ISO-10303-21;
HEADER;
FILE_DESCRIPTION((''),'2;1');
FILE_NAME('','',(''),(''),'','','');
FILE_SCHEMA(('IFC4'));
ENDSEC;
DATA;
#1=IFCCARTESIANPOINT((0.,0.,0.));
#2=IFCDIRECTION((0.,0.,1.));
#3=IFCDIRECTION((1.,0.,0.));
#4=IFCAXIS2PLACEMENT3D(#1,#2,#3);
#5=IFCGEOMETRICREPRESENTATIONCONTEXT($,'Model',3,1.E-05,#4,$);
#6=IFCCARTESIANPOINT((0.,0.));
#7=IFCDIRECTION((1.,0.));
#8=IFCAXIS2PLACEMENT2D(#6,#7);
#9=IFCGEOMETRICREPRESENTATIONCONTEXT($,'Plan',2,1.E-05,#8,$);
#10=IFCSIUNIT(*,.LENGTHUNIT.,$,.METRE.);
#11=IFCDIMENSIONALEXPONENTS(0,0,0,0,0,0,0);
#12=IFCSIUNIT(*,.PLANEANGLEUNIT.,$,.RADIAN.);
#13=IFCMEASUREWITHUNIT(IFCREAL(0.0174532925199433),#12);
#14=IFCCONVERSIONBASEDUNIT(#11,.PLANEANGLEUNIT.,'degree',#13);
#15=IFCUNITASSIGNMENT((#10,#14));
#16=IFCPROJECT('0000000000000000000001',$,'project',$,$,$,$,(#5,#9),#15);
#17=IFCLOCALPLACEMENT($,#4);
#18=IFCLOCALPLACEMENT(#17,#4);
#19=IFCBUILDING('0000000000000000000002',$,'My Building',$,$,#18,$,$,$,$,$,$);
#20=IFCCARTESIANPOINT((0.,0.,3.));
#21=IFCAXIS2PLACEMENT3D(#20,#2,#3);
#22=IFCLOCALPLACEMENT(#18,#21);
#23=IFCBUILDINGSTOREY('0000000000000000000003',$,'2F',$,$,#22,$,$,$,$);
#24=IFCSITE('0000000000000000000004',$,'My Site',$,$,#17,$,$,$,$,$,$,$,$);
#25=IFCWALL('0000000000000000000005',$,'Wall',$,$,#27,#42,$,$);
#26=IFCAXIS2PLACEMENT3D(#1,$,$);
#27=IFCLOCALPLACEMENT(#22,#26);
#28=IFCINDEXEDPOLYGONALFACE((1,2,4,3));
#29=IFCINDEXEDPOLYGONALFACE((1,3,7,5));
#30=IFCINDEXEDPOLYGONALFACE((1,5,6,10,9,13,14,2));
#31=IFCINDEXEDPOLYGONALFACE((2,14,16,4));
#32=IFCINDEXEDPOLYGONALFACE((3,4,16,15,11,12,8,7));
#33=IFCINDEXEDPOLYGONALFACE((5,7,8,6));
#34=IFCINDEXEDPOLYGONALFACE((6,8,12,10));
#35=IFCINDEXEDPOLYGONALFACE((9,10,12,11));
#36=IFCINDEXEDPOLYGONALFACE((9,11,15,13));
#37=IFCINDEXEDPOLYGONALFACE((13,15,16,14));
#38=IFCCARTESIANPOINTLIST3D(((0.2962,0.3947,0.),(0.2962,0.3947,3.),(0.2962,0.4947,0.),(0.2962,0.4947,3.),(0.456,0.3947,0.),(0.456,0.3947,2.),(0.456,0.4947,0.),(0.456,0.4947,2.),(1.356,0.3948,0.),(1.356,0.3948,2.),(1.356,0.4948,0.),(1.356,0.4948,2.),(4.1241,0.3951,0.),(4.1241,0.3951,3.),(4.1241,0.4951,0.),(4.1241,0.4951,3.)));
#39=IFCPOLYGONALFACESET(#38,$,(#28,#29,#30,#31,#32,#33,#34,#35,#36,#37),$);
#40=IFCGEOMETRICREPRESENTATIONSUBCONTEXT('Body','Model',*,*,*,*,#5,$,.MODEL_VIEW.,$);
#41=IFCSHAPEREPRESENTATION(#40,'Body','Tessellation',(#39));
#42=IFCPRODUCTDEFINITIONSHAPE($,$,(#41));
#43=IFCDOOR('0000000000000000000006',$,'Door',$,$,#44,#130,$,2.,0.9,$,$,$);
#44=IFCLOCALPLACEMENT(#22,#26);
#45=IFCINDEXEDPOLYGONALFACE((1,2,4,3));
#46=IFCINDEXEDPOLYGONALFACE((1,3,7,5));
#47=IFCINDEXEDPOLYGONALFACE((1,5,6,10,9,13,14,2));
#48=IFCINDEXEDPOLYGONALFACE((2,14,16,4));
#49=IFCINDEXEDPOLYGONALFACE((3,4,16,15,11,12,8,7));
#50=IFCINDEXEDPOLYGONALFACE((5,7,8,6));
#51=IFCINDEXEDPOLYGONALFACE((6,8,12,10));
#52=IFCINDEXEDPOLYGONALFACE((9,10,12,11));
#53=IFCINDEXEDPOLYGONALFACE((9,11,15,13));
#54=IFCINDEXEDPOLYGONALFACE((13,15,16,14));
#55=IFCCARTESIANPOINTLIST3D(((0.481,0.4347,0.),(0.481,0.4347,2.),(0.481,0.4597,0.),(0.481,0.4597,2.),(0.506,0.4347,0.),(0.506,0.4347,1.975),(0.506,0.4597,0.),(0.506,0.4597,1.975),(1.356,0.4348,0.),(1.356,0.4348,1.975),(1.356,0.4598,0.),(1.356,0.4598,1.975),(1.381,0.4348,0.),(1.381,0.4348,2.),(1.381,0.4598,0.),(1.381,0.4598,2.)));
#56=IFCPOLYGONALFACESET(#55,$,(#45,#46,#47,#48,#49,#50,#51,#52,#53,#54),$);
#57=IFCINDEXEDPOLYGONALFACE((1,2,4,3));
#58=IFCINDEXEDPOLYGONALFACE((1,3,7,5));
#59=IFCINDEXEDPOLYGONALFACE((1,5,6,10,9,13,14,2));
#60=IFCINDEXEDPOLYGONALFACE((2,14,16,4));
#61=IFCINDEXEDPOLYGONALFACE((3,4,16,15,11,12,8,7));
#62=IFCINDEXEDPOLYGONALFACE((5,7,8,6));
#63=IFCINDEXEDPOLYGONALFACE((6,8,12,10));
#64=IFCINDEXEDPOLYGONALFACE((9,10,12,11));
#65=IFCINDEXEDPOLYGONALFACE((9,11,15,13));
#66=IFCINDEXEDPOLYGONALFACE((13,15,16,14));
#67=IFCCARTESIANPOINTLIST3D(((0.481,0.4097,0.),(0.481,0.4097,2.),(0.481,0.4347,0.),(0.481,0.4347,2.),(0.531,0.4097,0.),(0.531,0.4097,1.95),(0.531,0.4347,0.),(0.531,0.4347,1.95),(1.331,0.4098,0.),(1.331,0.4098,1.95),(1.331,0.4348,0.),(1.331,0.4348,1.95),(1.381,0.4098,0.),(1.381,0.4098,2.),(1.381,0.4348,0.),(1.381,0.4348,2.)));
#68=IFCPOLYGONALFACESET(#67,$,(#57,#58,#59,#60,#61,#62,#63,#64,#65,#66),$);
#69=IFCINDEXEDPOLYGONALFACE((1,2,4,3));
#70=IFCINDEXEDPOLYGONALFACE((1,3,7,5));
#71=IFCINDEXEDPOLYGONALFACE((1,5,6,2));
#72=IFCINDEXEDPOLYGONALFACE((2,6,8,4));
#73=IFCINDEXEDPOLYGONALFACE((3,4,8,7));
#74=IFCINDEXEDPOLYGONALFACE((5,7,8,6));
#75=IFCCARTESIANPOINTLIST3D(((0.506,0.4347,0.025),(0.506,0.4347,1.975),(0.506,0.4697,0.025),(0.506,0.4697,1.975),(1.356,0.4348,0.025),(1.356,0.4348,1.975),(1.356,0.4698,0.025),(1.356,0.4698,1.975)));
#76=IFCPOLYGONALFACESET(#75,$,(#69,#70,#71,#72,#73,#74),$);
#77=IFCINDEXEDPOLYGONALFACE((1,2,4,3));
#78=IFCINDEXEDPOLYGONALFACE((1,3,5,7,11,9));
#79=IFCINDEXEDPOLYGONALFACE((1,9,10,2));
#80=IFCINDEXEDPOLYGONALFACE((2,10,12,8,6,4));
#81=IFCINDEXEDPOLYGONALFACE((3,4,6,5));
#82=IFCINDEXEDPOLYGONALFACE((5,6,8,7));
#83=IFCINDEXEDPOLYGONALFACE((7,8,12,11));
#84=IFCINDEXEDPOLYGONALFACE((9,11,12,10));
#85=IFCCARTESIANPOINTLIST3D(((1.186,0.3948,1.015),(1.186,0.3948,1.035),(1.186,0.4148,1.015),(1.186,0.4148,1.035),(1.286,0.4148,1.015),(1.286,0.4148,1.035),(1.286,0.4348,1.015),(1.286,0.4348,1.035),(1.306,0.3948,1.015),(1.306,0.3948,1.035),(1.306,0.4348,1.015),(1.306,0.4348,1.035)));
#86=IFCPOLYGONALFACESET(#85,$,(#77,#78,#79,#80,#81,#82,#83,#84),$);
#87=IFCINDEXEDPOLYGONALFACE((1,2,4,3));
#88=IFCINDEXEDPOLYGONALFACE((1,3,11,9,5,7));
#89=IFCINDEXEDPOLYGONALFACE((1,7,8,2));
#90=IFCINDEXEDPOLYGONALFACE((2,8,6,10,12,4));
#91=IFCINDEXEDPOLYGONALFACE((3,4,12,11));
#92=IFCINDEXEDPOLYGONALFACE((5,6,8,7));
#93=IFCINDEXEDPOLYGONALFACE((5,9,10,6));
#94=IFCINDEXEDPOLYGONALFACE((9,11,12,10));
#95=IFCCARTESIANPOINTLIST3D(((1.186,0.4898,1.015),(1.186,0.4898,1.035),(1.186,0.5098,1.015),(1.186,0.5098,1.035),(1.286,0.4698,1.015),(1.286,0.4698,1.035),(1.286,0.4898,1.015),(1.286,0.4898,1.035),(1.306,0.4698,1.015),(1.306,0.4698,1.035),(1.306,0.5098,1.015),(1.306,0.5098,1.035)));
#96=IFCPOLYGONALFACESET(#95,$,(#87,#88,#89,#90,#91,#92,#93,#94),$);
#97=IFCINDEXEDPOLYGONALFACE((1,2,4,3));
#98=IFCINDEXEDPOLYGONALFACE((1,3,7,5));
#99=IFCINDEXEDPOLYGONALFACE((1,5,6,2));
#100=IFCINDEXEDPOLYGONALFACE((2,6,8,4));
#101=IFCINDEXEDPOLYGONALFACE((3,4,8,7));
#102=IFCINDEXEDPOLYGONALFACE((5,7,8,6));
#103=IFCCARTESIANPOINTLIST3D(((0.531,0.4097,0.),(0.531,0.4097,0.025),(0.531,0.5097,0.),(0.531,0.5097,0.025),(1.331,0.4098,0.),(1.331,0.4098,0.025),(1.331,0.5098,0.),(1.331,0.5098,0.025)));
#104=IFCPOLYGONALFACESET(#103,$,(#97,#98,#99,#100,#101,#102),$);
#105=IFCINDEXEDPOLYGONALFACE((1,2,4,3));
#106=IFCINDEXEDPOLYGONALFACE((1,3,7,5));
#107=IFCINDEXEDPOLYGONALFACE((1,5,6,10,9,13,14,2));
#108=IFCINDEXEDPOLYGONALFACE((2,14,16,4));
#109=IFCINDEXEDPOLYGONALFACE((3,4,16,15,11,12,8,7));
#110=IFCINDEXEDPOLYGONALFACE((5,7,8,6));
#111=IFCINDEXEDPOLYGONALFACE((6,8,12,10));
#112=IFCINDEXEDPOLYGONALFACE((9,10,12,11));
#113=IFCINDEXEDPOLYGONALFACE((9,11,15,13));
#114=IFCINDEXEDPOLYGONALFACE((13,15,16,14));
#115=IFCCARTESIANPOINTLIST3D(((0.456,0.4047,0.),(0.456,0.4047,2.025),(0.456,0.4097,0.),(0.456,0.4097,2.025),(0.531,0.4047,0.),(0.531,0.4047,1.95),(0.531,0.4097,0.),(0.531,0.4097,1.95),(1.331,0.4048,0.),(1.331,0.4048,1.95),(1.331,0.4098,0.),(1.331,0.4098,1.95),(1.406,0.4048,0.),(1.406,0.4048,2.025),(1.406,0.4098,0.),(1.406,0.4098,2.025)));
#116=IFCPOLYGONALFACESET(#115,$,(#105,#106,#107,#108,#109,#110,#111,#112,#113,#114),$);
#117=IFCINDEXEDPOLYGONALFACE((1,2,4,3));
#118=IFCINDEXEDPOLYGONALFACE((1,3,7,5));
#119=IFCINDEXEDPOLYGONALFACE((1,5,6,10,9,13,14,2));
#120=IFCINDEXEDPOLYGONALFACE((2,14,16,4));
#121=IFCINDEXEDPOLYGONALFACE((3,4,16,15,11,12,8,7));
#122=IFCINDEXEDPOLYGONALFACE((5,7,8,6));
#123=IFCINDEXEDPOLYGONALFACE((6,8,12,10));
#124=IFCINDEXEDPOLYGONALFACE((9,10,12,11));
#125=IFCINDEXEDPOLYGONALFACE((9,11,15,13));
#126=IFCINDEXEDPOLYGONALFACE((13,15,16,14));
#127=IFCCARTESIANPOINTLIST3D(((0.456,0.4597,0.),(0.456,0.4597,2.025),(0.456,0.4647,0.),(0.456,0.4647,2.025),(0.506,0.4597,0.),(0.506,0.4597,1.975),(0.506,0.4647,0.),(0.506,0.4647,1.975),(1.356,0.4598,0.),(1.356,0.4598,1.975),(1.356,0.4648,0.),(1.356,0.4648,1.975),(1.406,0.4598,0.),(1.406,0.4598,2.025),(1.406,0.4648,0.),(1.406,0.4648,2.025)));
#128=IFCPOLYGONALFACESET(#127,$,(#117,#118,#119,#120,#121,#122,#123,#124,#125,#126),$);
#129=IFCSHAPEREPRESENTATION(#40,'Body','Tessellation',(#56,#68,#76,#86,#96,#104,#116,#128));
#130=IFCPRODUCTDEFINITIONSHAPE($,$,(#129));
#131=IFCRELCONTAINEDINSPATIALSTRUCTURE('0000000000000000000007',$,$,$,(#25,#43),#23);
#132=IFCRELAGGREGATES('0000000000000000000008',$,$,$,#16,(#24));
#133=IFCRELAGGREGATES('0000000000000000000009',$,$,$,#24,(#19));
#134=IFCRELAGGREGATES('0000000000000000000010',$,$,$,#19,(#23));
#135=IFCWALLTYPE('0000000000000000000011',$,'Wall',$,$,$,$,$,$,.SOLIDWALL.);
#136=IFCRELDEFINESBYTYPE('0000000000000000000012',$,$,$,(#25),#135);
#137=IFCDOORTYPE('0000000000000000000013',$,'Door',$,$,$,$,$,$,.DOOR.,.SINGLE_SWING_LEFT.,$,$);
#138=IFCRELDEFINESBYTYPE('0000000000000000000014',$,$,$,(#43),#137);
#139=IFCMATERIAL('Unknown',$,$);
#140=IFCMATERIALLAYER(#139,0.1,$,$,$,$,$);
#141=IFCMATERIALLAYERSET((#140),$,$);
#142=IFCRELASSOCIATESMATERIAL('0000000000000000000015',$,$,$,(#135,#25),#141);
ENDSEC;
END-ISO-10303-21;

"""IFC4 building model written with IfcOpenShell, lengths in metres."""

from ifc_helpers import new_model, entity, si_unit, converted_unit, frame, origin_with_axes, origin_2d_with_axis, place, context, subcontext, project, spatial, line, indexed_curve, outline, extrude, shape, source, transform, mapped, material, layer, layer_set, layer_usage, type_object, type_shapes, element, fill, save


model = new_model("IFC4")

# Units and contexts
model_context = context("Model", 3, precision=1e-05, world=origin_with_axes())
plan_context = context("Plan", 2, precision=1e-05, world=origin_2d_with_axis())
body_context_1 = subcontext(model_context, "Body", "Model", "MODEL_VIEW")
body_context_2 = subcontext(plan_context, "Body", "Plan", "PLAN_VIEW")
ifc_project = project(units=[si_unit("LENGTHUNIT", "METRE"), converted_unit("PLANEANGLEUNIT", "degree", entity("IfcReal", 0.0174532925199433), si_unit("PLANEANGLEUNIT", "RADIAN"), dimensions=[0, 0, 0, 0, 0, 0, 0])], contexts=[model_context, plan_context])

# Site, building, storey
site_placement = place(None, origin_with_axes())
site = spatial("IfcSite", under=ifc_project, at=site_placement, Name="My Site")
building_placement = place(site_placement, origin_with_axes())
building = spatial("IfcBuilding", under=site, at=building_placement, Name="My Building")
storey_placement = place(building_placement, frame((0.0, 0.0, 3.0), z_axis=(0.0, 0.0, 1.0), x_axis=(1.0, 0.0, 0.0)))
storey = spatial("IfcBuildingStorey", under=building, at=storey_placement, Name="2F")

# Shared definitions
ifc_material = material(Name="Unknown")

# Shared definitions
ifc_layer_1 = layer(ifc_material, 0.1)
ifc_layer_set_1 = layer_set([ifc_layer_1])
wall_type = type_object("IfcWallType", Name="Wall", PredefinedType="SOLIDWALL", material=ifc_layer_set_1)

# Shared definitions
shared_shape_1 = source(origin_with_axes(), body_context_1, "Body", "SweptSolid", [
    extrude(outline(indexed_curve([(0.0, 0.0), (0.9, 0.0), (0.9, 2.0), (0.0, 2.0)], segments=[line(1, 2, 3, 4, 1)])), frame((0.0, -0.6, 0.0), z_axis=(0.0, -1.0, 0.0), x_axis=(1.0, 0.0, 0.0)), (0.0, 0.0, -1.0), 1.2),
])
door_type_1 = type_object("IfcDoorType", Name="Door", OperationType="SINGLE_SWING_LEFT", PredefinedType="DOOR")
shared_shape_2 = source(origin_with_axes(), body_context_1, "Body", "SweptSolid", [
    extrude(outline(indexed_curve([(0.0, 0.0), (0.0, 2.0), (0.9, 2.0), (0.9, 0.0), (0.875, 0.0), (0.875, 1.975), (0.025, 1.975), (0.025, 0.0)], segments=[line(1, 2, 3, 4, 5, 6, 7, 8, 1)])), frame((0.0, 0.025, 0.0), z_axis=(0.0, -1.0, 0.0), x_axis=(1.0, 0.0, 0.0)), (0.0, 0.0, -1.0), 0.025),
    extrude(outline(indexed_curve([(0.0, 0.0), (0.0, 2.0), (0.9, 2.0), (0.9, 0.0), (0.85, 0.0), (0.85, 1.95), (0.05, 1.95), (0.05, 0.0)], segments=[line(1, 2, 3, 4, 5, 6, 7, 8, 1)])), frame((0.0, 0.0, 0.0), z_axis=(0.0, -1.0, 0.0), x_axis=(1.0, 0.0, 0.0)), (0.0, 0.0, -1.0), 0.025),
    extrude(outline(indexed_curve([(0.0, 0.0), (0.85, 0.0), (0.85, 0.035), (0.0, 0.035)], segments=[line(1, 2, 3, 4, 1)])), frame((0.025, 0.025, 0.025), z_axis=(0.0, 0.0, 1.0), x_axis=(1.0, 0.0, 0.0)), (0.0, 0.0, 1.0), 1.95),
    extrude(outline(indexed_curve([(0.0, 0.0), (0.0, -0.04), (-0.12, -0.04), (-0.12, -0.02), (-0.02, -0.02), (-0.02, 0.0)], segments=[line(1, 2, 3, 4, 5, 6, 1)])), frame((0.825, 0.025, 1.015), z_axis=(0.0, 0.0, 1.0), x_axis=(1.0, 0.0, 0.0)), (0.0, 0.0, 1.0), 0.02),
    extrude(outline(indexed_curve([(0.0, 0.0), (0.0, 0.04), (-0.12, 0.04), (-0.12, 0.02), (-0.02, 0.02), (-0.02, 0.0)], segments=[line(1, 2, 3, 4, 5, 6, 1)])), frame((0.825, 0.06, 1.015), z_axis=(0.0, 0.0, 1.0), x_axis=(1.0, 0.0, 0.0)), (0.0, 0.0, 1.0), 0.02),
    extrude(outline(indexed_curve([(0.0, 0.0), (0.8, 0.0), (0.8, 0.1), (0.0, 0.1)], segments=[line(1, 2, 3, 4, 1)])), frame((0.05, 0.0, 0.0), z_axis=(0.0, 0.0, 1.0), x_axis=(1.0, 0.0, 0.0)), (0.0, 0.0, 1.0), 0.025),
    extrude(outline(indexed_curve([(0.0, 0.0), (0.0, 2.025), (0.95, 2.025), (0.95, 0.0), (0.875, 0.0), (0.875, 1.95), (0.075, 1.95), (0.075, 0.0)], segments=[line(1, 2, 3, 4, 5, 6, 7, 8, 1)])), frame((-0.025, -0.005, 0.0), z_axis=(0.0, -1.0, 0.0), x_axis=(1.0, 0.0, 0.0)), (0.0, 0.0, -1.0), 0.005),
    extrude(outline(indexed_curve([(0.0, 0.0), (0.0, 2.025), (0.95, 2.025), (0.95, 0.0), (0.9, 0.0), (0.9, 1.975), (0.05, 1.975), (0.05, 0.0)], segments=[line(1, 2, 3, 4, 5, 6, 7, 8, 1)])), frame((-0.025, 0.05, 0.0), z_axis=(0.0, -1.0, 0.0), x_axis=(1.0, 0.0, 0.0)), (0.0, 0.0, -1.0), 0.005),
])
shared_shape_3 = source(origin_with_axes(), body_context_2, "Body", "Curve2D", [
    entity("IfcIndexedPolyCurve", entity("IfcCartesianPointList2D", [[0.0, 0.0], [0.0, 0.05], [0.025, 0.05], [0.025, 0.025], [0.05, 0.025], [0.05, 0.0]]), [entity("IfcLineIndex", [1, 2, 3, 4, 5, 6, 1])]),
    entity("IfcIndexedPolyCurve", entity("IfcCartesianPointList2D", [[0.9, 0.0], [0.9, 0.05], [0.875, 0.05], [0.875, 0.025], [0.85, 0.025], [0.85, 0.0]]), [entity("IfcLineIndex", [1, 2, 3, 4, 5, 6, 1])]),
    entity("IfcTrimmedCurve", entity("IfcEllipse", entity("IfcAxis2Placement2D", entity("IfcCartesianPoint", [0.06, 0.05]), entity("IfcDirection", [1.0, 0.0])), 0.815, 0.85), [entity("IfcCartesianPoint", [0.875, 0.05])], [entity("IfcCartesianPoint", [0.06, 0.9])], True, "CARTESIAN"),
    entity("IfcIndexedPolyCurve", entity("IfcCartesianPointList2D", [[0.025, 0.05], [0.06, 0.05], [0.06, 0.9], [0.025, 0.9]]), [entity("IfcLineIndex", [1, 2, 3, 4, 1])]),
])
type_shapes(door_type_1, [shared_shape_2, shared_shape_3])

# Wall, opening, door
ifc_layer_usage_1 = layer_usage(ifc_layer_set_1, "AXIS2", "POSITIVE", 0.0)
wall_1_placement = place(storey_placement, frame((4.1241, 0.4951, 0.0), z_axis=(0.0, 0.0, 1.0), x_axis=(-1.0, -0.000094, 0.0)))
wall_1 = element("IfcWall", 1, at=wall_1_placement, inside=storey, type_object=wall_type, material=ifc_layer_usage_1, Name="Wall", context=body_context_1, shape_type="SweptSolid", body=[
    extrude(outline(indexed_curve([(0.0, 0.0), (0.0, 0.1), (3.8279, 0.1), (3.8279, 0.0)], segments=[line(1, 2, 3, 4, 1)])), origin_with_axes(), (0.0, 0.0, 1.0), 3.0),
])
opening_1_placement = place(wall_1_placement, frame((2.7681, 0.0, 0.0), z_axis=(0.0, 0.0, 1.0), x_axis=(1.0, 0.0, 0.0)))
opening_1 = element("IfcOpeningElement", 2, at=opening_1_placement, cuts=wall_1, PredefinedType="OPENING", context=body_context_1, shape_type="MappedRepresentation", body=[
    mapped(shared_shape_1, transform((0.0, 0.0, 0.0), x_axis=(1.0, 0.0, 0.0), y_axis=(0.0, 1.0, 0.0), z_axis=(0.0, 0.0, 1.0), scale=1.0)),
])
door_1_placement = place(opening_1_placement, frame((0.875, 0.085, 0.0), z_axis=(0.0, 0.0, 1.0), x_axis=(-1.0, 0.0, 0.0)))
door_1 = element("IfcDoor", 3, at=door_1_placement, inside=storey, type_object=door_type_1, Name="Door", OverallHeight=2.0, OverallWidth=0.9, shapes=[
    shape(body_context_1, "Body", "MappedRepresentation", [mapped(shared_shape_2, transform((0.0, 0.0, 0.0), x_axis=(1.0, 0.0, 0.0), y_axis=(0.0, 1.0, 0.0), z_axis=(0.0, 0.0, 1.0), scale=1.0))]),
    shape(body_context_2, "Body", "MappedRepresentation", [mapped(shared_shape_3, transform((0.0, 0.0, 0.0), x_axis=(1.0, 0.0, 0.0), y_axis=(0.0, 1.0, 0.0), z_axis=(0.0, 0.0, 1.0), scale=1.0))]),
])
fill(opening_1, door_1)

save(model, "model.ifc")
